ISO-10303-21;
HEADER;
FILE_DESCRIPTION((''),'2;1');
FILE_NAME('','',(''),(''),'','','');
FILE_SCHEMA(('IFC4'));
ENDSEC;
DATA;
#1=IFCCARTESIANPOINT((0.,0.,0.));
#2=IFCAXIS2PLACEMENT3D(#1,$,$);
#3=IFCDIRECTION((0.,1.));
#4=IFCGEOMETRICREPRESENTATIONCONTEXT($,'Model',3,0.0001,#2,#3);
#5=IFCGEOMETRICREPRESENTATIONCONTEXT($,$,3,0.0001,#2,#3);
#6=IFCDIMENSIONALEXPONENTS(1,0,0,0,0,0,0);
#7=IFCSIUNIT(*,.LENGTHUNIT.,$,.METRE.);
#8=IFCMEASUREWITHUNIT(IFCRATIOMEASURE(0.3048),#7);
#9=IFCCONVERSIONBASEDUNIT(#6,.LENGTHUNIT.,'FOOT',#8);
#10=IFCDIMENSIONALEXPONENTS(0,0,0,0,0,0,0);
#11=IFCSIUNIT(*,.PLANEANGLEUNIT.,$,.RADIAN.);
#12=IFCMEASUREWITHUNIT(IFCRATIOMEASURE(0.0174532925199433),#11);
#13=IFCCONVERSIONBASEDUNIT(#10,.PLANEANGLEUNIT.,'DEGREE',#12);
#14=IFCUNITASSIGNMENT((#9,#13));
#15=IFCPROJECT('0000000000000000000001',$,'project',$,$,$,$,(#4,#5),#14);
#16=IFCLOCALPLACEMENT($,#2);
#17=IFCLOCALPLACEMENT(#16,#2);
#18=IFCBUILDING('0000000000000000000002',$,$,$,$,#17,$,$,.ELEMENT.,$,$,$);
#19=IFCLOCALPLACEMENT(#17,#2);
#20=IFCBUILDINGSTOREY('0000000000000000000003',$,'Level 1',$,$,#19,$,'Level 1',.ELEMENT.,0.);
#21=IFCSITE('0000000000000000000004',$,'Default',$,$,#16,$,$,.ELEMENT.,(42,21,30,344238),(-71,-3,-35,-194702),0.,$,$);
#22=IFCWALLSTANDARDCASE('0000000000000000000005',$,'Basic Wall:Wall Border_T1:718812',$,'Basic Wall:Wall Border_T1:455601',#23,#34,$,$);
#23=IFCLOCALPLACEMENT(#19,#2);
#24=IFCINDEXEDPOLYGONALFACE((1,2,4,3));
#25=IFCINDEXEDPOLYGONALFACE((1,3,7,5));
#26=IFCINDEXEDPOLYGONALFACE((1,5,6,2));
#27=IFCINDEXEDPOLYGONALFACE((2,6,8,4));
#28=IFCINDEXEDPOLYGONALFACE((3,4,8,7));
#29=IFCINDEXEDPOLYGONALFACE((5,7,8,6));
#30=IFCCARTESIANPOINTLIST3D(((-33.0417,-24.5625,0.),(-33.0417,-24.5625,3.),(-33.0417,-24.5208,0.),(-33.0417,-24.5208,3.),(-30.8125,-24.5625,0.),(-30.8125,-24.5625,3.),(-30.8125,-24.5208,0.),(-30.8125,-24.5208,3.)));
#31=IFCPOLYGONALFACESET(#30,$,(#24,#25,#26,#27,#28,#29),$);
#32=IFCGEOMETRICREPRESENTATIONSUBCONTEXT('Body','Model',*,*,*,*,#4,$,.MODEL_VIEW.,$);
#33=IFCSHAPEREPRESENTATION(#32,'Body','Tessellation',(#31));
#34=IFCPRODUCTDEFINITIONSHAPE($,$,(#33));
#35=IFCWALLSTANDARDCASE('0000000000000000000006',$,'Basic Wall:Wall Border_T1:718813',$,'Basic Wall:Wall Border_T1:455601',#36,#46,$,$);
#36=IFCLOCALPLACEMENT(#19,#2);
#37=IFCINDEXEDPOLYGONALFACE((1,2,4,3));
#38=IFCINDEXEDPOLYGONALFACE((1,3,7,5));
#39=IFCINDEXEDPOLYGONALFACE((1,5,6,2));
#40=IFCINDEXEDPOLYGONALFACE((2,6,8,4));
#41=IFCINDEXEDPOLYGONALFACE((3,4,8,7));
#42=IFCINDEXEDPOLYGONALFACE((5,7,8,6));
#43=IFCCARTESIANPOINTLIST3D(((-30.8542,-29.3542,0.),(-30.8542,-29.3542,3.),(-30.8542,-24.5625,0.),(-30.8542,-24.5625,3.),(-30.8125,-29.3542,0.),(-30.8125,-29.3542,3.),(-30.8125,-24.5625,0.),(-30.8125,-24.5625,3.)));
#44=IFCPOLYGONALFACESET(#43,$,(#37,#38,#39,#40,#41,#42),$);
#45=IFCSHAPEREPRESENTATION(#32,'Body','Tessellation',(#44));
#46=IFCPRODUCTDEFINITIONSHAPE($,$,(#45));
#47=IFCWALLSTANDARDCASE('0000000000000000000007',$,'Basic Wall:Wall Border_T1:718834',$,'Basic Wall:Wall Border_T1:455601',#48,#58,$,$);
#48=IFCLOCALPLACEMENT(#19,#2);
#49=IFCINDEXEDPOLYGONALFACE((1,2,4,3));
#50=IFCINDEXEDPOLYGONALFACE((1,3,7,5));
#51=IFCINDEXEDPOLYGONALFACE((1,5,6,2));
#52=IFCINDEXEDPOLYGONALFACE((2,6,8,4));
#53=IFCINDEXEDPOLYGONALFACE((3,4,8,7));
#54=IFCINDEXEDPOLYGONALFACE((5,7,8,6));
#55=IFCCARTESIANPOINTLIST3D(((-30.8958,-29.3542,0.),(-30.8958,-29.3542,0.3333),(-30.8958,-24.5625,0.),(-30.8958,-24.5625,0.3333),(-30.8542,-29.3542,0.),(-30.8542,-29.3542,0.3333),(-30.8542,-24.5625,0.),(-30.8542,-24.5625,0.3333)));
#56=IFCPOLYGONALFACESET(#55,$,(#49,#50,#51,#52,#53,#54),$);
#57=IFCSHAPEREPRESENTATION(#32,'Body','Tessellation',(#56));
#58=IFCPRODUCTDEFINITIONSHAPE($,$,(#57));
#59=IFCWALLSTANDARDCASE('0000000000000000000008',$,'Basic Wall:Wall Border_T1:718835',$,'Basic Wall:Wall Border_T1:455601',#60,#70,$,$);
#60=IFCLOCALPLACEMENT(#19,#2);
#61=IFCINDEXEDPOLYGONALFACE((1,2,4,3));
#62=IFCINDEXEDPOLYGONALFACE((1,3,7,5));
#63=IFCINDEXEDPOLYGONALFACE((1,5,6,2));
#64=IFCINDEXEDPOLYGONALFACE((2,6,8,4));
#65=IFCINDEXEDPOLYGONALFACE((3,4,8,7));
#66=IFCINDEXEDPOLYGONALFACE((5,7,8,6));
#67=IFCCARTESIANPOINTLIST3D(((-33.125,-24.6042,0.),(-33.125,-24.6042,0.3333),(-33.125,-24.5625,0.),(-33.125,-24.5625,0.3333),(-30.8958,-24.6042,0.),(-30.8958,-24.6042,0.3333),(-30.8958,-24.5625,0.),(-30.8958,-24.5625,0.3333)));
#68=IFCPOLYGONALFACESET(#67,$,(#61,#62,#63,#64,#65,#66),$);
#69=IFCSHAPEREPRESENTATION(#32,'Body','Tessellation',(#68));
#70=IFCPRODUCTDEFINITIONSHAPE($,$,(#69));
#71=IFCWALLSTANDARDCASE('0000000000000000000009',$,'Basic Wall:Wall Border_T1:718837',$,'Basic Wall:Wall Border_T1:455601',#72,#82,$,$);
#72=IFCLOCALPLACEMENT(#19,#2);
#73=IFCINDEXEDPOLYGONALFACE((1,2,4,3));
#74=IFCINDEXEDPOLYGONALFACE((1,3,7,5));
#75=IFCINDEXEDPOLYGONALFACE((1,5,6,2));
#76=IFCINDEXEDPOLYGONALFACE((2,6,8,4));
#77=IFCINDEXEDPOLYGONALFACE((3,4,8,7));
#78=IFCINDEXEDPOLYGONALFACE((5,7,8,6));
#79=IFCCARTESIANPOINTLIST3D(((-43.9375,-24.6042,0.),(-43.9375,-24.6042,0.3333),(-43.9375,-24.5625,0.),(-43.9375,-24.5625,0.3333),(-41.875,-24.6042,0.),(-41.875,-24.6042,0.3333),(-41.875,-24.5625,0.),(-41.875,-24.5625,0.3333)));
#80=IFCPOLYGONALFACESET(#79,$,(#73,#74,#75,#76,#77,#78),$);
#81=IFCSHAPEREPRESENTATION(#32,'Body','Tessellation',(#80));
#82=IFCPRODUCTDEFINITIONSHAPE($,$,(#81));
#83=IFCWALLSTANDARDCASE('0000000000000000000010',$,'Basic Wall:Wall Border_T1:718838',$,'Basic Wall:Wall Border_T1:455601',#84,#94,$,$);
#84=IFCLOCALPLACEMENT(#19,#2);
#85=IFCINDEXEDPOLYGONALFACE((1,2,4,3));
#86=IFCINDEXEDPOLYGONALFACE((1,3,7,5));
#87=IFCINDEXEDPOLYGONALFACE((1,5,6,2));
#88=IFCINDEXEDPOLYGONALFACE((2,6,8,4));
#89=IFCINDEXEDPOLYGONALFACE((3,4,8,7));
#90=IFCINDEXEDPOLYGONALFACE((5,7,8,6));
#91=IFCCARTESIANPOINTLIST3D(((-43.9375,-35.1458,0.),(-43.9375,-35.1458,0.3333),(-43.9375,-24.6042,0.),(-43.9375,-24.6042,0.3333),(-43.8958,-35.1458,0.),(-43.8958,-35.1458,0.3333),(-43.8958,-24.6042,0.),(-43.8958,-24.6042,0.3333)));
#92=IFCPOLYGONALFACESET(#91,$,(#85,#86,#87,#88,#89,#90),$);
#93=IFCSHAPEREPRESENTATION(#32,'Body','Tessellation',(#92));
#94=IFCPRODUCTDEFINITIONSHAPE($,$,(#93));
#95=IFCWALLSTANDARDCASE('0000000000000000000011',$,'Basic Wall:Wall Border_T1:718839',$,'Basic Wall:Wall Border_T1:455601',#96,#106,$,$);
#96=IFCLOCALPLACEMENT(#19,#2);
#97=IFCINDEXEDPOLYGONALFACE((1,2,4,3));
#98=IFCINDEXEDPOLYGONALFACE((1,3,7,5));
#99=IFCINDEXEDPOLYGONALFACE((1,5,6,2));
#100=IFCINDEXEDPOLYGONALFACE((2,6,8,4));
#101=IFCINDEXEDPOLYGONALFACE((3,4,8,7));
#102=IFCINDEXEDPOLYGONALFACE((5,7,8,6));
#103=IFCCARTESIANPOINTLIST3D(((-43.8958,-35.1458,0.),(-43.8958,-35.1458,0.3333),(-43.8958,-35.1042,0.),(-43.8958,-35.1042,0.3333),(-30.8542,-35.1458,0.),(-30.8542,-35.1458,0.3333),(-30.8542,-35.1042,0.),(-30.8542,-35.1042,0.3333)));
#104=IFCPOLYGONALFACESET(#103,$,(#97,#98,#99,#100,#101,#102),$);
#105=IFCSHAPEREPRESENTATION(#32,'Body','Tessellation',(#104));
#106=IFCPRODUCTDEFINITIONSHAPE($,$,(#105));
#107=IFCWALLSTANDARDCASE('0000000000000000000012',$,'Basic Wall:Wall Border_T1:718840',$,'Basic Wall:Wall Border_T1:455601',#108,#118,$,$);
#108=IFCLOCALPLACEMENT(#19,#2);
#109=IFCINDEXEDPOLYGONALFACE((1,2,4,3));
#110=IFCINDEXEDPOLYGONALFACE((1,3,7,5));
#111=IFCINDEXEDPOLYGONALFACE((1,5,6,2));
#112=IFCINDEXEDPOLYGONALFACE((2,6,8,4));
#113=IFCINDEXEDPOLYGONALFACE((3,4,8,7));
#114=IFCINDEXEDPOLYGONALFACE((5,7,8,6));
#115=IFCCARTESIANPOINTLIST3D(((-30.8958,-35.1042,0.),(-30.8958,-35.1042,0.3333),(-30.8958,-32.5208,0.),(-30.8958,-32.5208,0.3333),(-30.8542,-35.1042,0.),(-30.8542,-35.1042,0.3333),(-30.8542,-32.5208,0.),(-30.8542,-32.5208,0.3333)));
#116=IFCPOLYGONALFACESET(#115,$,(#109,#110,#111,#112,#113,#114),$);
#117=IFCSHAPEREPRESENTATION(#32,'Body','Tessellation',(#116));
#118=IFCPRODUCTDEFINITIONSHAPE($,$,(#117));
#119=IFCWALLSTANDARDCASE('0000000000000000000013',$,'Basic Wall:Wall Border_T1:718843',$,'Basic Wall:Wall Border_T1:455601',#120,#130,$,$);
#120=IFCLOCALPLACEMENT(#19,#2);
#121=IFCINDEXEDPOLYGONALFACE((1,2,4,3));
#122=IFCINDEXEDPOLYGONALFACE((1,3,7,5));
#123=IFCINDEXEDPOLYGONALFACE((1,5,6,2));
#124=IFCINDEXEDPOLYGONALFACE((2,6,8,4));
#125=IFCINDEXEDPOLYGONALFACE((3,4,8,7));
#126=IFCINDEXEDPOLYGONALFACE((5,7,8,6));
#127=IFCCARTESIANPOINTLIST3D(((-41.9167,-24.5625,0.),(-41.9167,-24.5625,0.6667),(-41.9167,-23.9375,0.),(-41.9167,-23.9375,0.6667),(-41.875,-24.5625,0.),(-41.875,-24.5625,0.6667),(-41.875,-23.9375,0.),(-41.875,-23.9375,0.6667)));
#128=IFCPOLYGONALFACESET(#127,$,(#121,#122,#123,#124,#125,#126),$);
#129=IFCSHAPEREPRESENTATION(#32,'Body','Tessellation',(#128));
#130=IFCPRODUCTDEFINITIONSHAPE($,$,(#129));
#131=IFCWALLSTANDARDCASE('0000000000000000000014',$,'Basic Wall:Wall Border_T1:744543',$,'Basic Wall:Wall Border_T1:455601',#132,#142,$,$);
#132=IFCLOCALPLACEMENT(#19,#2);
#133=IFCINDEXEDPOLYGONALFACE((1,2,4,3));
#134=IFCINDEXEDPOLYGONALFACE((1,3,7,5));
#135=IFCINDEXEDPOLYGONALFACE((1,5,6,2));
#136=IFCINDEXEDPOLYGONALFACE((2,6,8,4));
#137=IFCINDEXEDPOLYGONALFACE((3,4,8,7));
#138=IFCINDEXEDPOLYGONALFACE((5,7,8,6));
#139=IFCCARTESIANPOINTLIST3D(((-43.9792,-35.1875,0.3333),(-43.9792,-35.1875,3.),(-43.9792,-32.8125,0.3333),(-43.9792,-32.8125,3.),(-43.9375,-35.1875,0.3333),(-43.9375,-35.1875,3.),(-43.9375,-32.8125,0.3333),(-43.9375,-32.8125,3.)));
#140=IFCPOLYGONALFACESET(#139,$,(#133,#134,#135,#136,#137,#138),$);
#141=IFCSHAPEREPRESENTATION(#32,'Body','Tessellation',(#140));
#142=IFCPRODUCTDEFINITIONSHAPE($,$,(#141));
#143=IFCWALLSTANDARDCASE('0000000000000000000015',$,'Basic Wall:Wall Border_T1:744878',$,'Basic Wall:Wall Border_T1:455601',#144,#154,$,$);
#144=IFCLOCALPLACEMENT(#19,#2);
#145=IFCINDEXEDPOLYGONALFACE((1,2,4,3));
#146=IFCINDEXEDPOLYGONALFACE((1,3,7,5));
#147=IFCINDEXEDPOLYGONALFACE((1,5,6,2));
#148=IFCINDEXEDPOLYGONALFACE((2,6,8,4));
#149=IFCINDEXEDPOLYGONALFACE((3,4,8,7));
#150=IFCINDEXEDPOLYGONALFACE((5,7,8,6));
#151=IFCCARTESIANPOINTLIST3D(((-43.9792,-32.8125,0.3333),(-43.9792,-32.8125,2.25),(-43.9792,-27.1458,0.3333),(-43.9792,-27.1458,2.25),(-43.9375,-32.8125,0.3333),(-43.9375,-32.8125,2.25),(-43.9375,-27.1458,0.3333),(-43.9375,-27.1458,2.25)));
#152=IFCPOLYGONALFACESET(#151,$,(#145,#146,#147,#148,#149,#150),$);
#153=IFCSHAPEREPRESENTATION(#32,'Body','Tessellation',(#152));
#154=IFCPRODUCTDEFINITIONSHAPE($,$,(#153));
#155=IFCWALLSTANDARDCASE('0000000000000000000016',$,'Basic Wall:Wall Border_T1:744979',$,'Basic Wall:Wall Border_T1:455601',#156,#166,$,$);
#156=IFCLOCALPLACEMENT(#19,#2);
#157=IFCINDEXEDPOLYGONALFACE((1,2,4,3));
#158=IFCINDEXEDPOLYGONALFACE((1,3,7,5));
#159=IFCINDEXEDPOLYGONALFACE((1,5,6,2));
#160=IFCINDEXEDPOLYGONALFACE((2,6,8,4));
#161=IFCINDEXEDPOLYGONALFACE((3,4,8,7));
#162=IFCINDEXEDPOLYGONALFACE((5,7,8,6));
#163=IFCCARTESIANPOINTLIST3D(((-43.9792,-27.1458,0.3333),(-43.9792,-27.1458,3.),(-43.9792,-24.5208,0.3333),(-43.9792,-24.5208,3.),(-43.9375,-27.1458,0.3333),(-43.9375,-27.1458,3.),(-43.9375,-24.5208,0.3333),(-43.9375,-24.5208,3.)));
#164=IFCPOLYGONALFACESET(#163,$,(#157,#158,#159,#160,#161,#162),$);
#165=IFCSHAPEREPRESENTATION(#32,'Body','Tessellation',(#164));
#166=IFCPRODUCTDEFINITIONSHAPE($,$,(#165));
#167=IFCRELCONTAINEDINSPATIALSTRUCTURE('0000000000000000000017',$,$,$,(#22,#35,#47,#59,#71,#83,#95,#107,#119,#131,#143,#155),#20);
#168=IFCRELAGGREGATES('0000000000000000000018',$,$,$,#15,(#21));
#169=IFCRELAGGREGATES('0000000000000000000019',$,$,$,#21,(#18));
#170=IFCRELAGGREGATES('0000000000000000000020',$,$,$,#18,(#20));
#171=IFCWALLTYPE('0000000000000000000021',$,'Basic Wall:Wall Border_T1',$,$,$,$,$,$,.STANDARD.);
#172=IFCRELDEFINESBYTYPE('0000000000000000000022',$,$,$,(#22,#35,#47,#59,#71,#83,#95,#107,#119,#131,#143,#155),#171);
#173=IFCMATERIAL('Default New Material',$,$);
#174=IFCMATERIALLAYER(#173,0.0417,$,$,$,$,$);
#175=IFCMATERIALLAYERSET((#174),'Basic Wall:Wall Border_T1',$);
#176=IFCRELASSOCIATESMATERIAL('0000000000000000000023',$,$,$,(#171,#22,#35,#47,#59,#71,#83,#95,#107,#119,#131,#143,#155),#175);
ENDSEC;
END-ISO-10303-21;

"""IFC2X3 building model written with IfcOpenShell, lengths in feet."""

from ifc_helpers import new_model, entity, si_unit, converted_unit, direction, frame, frame_2d, origin, place, context, subcontext, project, spatial, rectangle, extrude, material, layer, layer_set, layer_usage, type_object, element, save


model = new_model("IFC2X3")

# Units and contexts
model_context = context("Model", 3, precision=0.0001, world=origin(), true_north=direction((0.0, 1.0)))
context_of_model = context(None, 3, precision=0.0001, world=origin(), true_north=direction((0.0, 1.0)))
body_context = subcontext(model_context, "Body", "Model", "MODEL_VIEW")
ifc_project = project(units=[converted_unit("LENGTHUNIT", "FOOT", entity("IfcRatioMeasure", 0.3048), si_unit("LENGTHUNIT", "METRE"), dimensions=[1, 0, 0, 0, 0, 0, 0]), converted_unit("PLANEANGLEUNIT", "DEGREE", entity("IfcRatioMeasure", 0.0174532925199433), si_unit("PLANEANGLEUNIT", "RADIAN"), dimensions=[0, 0, 0, 0, 0, 0, 0])], contexts=[model_context, context_of_model])

# Site, building, storey
site_placement = place(None, origin())
site = spatial("IfcSite", under=ifc_project, at=site_placement, Name="Default", CompositionType="ELEMENT", RefLatitude=(42, 21, 30, 344238), RefLongitude=(-71, -3, -35, -194702), RefElevation=0.0)
building_placement = place(site_placement, origin())
building = spatial("IfcBuilding", under=site, at=building_placement, CompositionType="ELEMENT")
storey_placement = place(building_placement, origin())
storey = spatial("IfcBuildingStorey", under=building, at=storey_placement, Name="Level 1", LongName="Level 1", CompositionType="ELEMENT", Elevation=0.0)

# Shared definitions
ifc_material_1 = material(Name="Default New Material")

# Walls
ifc_layer_1 = layer(ifc_material_1, 0.0417)
ifc_layer_set_1 = layer_set([ifc_layer_1], Name="Basic Wall:Wall Border_T1")
wall_type_1 = type_object("IfcWallType", Name="Basic Wall:Wall Border_T1", PredefinedType="STANDARD", material=ifc_layer_set_1)
ifc_layer_usage_1 = layer_usage(ifc_layer_set_1, "AXIS2", "NEGATIVE", 0.0208)
wall_1_placement = place(storey_placement, frame((-30.8125, -24.5417, 0.0), z_axis=(0.0, 0.0, 1.0), x_axis=(-1.0, 0.0, 0.0)))
element("IfcWallStandardCase", 1, at=wall_1_placement, inside=storey, type_object=wall_type_1, material=ifc_layer_usage_1, Name="Basic Wall:Wall Border_T1:718812", ObjectType="Basic Wall:Wall Border_T1:455601", context=body_context, shape_type="SweptSolid", body=[
    extrude(rectangle(XDim=2.2292, YDim=0.0417, at=frame_2d((1.1146, 0.0), x_axis=(-1.0, 0.0))), origin(), (0.0, 0.0, 1.0), 3.0),
])
ifc_layer_usage_2 = layer_usage(ifc_layer_set_1, "AXIS2", "POSITIVE", -0.0208)
wall_2_placement = place(storey_placement, frame((-30.8333, -24.5625, 0.0), z_axis=(0.0, 0.0, 1.0), x_axis=(0.0, -1.0, 0.0)))
element("IfcWallStandardCase", 2, at=wall_2_placement, inside=storey, type_object=wall_type_1, material=ifc_layer_usage_2, Name="Basic Wall:Wall Border_T1:718813", ObjectType="Basic Wall:Wall Border_T1:455601", context=body_context, shape_type="SweptSolid", body=[
    extrude(rectangle(XDim=4.7917, YDim=0.0417, at=frame_2d((2.3958, 0.0), x_axis=(-1.0, 0.0))), origin(), (0.0, 0.0, 1.0), 3.0),
])
ifc_layer_usage_3 = layer_usage(ifc_layer_set_1, "AXIS2", "POSITIVE", -0.0208)
wall_3_placement = place(storey_placement, frame((-30.875, -24.5625, 0.0), z_axis=(0.0, 0.0, 1.0), x_axis=(0.0, -1.0, 0.0)))
element("IfcWallStandardCase", 3, at=wall_3_placement, inside=storey, type_object=wall_type_1, material=ifc_layer_usage_3, Name="Basic Wall:Wall Border_T1:718834", ObjectType="Basic Wall:Wall Border_T1:455601", context=body_context, shape_type="SweptSolid", body=[
    extrude(rectangle(XDim=4.7917, YDim=0.0417, at=frame_2d((2.3958, 0.0), x_axis=(-1.0, 0.0))), origin(), (0.0, 0.0, 1.0), 0.3333),
])
ifc_layer_usage_4 = layer_usage(ifc_layer_set_1, "AXIS2", "NEGATIVE", 0.0208)
wall_4_placement = place(storey_placement, frame((-30.8958, -24.5833, 0.0), z_axis=(0.0, 0.0, 1.0), x_axis=(-1.0, 0.0, 0.0)))
element("IfcWallStandardCase", 4, at=wall_4_placement, inside=storey, type_object=wall_type_1, material=ifc_layer_usage_4, Name="Basic Wall:Wall Border_T1:718835", ObjectType="Basic Wall:Wall Border_T1:455601", context=body_context, shape_type="SweptSolid", body=[
    extrude(rectangle(XDim=2.2292, YDim=0.0417, at=frame_2d((1.1146, 0.0), x_axis=(-1.0, 0.0))), origin(), (0.0, 0.0, 1.0), 0.3333),
])
ifc_layer_usage_5 = layer_usage(ifc_layer_set_1, "AXIS2", "POSITIVE", -0.0208)
wall_5_placement = place(storey_placement, frame((-43.9375, -24.5833, 0.0)))
element("IfcWallStandardCase", 5, at=wall_5_placement, inside=storey, type_object=wall_type_1, material=ifc_layer_usage_5, Name="Basic Wall:Wall Border_T1:718837", ObjectType="Basic Wall:Wall Border_T1:455601", context=body_context, shape_type="SweptSolid", body=[
    extrude(rectangle(XDim=2.0625, YDim=0.0417, at=frame_2d((1.0312, 0.0), x_axis=(-1.0, 0.0))), origin(), (0.0, 0.0, 1.0), 0.3333),
])
ifc_layer_usage_6 = layer_usage(ifc_layer_set_1, "AXIS2", "NEGATIVE", 0.0208)
wall_6_placement = place(storey_placement, frame((-43.9167, -24.6042, 0.0), z_axis=(0.0, 0.0, 1.0), x_axis=(0.0, -1.0, 0.0)))
element("IfcWallStandardCase", 6, at=wall_6_placement, inside=storey, type_object=wall_type_1, material=ifc_layer_usage_6, Name="Basic Wall:Wall Border_T1:718838", ObjectType="Basic Wall:Wall Border_T1:455601", context=body_context, shape_type="SweptSolid", body=[
    extrude(rectangle(XDim=10.5417, YDim=0.0417, at=frame_2d((5.2708, 0.0), x_axis=(-1.0, 0.0))), origin(), (0.0, 0.0, 1.0), 0.3333),
])
ifc_layer_usage_7 = layer_usage(ifc_layer_set_1, "AXIS2", "NEGATIVE", 0.0208)
wall_7_placement = place(storey_placement, frame((-43.8958, -35.125, 0.0)))
element("IfcWallStandardCase", 7, at=wall_7_placement, inside=storey, type_object=wall_type_1, material=ifc_layer_usage_7, Name="Basic Wall:Wall Border_T1:718839", ObjectType="Basic Wall:Wall Border_T1:455601", context=body_context, shape_type="SweptSolid", body=[
    extrude(rectangle(XDim=13.0417, YDim=0.0417, at=frame_2d((6.5208, 0.0), x_axis=(-1.0, 0.0))), origin(), (0.0, 0.0, 1.0), 0.3333),
])
ifc_layer_usage_8 = layer_usage(ifc_layer_set_1, "AXIS2", "NEGATIVE", 0.0208)
wall_8_placement = place(storey_placement, frame((-30.875, -35.1042, 0.0), z_axis=(0.0, 0.0, 1.0), x_axis=(0.0, 1.0, 0.0)))
element("IfcWallStandardCase", 8, at=wall_8_placement, inside=storey, type_object=wall_type_1, material=ifc_layer_usage_8, Name="Basic Wall:Wall Border_T1:718840", ObjectType="Basic Wall:Wall Border_T1:455601", context=body_context, shape_type="SweptSolid", body=[
    extrude(rectangle(XDim=2.5833, YDim=0.0417, at=frame_2d((1.2917, 0.0), x_axis=(-1.0, 0.0))), origin(), (0.0, 0.0, 1.0), 0.3333),
])
ifc_layer_usage_9 = layer_usage(ifc_layer_set_1, "AXIS2", "POSITIVE", -0.0208)
wall_9_placement = place(storey_placement, frame((-41.8958, -24.5625, 0.0), z_axis=(0.0, 0.0, 1.0), x_axis=(0.0, 1.0, 0.0)))
element("IfcWallStandardCase", 9, at=wall_9_placement, inside=storey, type_object=wall_type_1, material=ifc_layer_usage_9, Name="Basic Wall:Wall Border_T1:718843", ObjectType="Basic Wall:Wall Border_T1:455601", context=body_context, shape_type="SweptSolid", body=[
    extrude(rectangle(XDim=0.625, YDim=0.0417, at=frame_2d((0.3125, 0.0), x_axis=(-1.0, 0.0))), origin(), (0.0, 0.0, 1.0), 0.6667),
])
ifc_layer_usage_10 = layer_usage(ifc_layer_set_1, "AXIS2", "POSITIVE", -0.0208)
wall_10_placement = place(storey_placement, frame((-43.9583, -35.1875, 0.3333), z_axis=(0.0, 0.0, 1.0), x_axis=(0.0, 1.0, 0.0)))
element("IfcWallStandardCase", 10, at=wall_10_placement, inside=storey, type_object=wall_type_1, material=ifc_layer_usage_10, Name="Basic Wall:Wall Border_T1:744543", ObjectType="Basic Wall:Wall Border_T1:455601", context=body_context, shape_type="SweptSolid", body=[
    extrude(rectangle(XDim=2.375, YDim=0.0417, at=frame_2d((1.1875, 0.0), x_axis=(-1.0, 0.0))), origin(), (0.0, 0.0, 1.0), 2.6667),
])
ifc_layer_usage_11 = layer_usage(ifc_layer_set_1, "AXIS2", "POSITIVE", -0.0208)
wall_11_placement = place(storey_placement, frame((-43.9583, -32.8125, 0.3333), z_axis=(0.0, 0.0, 1.0), x_axis=(0.0, 1.0, 0.0)))
element("IfcWallStandardCase", 11, at=wall_11_placement, inside=storey, type_object=wall_type_1, material=ifc_layer_usage_11, Name="Basic Wall:Wall Border_T1:744878", ObjectType="Basic Wall:Wall Border_T1:455601", context=body_context, shape_type="SweptSolid", body=[
    extrude(rectangle(XDim=5.6667, YDim=0.0417, at=frame_2d((2.8333, 0.0), x_axis=(-1.0, 0.0))), origin(), (0.0, 0.0, 1.0), 1.9167),
])
ifc_layer_usage_12 = layer_usage(ifc_layer_set_1, "AXIS2", "POSITIVE", -0.0208)
wall_12_placement = place(storey_placement, frame((-43.9583, -27.1458, 0.3333), z_axis=(0.0, 0.0, 1.0), x_axis=(0.0, 1.0, 0.0)))
element("IfcWallStandardCase", 12, at=wall_12_placement, inside=storey, type_object=wall_type_1, material=ifc_layer_usage_12, Name="Basic Wall:Wall Border_T1:744979", ObjectType="Basic Wall:Wall Border_T1:455601", context=body_context, shape_type="SweptSolid", body=[
    extrude(rectangle(XDim=2.625, YDim=0.0417, at=frame_2d((1.3125, 0.0), x_axis=(-1.0, 0.0))), origin(), (0.0, 0.0, 1.0), 2.6667),
])

save(model, "model.ifc")
